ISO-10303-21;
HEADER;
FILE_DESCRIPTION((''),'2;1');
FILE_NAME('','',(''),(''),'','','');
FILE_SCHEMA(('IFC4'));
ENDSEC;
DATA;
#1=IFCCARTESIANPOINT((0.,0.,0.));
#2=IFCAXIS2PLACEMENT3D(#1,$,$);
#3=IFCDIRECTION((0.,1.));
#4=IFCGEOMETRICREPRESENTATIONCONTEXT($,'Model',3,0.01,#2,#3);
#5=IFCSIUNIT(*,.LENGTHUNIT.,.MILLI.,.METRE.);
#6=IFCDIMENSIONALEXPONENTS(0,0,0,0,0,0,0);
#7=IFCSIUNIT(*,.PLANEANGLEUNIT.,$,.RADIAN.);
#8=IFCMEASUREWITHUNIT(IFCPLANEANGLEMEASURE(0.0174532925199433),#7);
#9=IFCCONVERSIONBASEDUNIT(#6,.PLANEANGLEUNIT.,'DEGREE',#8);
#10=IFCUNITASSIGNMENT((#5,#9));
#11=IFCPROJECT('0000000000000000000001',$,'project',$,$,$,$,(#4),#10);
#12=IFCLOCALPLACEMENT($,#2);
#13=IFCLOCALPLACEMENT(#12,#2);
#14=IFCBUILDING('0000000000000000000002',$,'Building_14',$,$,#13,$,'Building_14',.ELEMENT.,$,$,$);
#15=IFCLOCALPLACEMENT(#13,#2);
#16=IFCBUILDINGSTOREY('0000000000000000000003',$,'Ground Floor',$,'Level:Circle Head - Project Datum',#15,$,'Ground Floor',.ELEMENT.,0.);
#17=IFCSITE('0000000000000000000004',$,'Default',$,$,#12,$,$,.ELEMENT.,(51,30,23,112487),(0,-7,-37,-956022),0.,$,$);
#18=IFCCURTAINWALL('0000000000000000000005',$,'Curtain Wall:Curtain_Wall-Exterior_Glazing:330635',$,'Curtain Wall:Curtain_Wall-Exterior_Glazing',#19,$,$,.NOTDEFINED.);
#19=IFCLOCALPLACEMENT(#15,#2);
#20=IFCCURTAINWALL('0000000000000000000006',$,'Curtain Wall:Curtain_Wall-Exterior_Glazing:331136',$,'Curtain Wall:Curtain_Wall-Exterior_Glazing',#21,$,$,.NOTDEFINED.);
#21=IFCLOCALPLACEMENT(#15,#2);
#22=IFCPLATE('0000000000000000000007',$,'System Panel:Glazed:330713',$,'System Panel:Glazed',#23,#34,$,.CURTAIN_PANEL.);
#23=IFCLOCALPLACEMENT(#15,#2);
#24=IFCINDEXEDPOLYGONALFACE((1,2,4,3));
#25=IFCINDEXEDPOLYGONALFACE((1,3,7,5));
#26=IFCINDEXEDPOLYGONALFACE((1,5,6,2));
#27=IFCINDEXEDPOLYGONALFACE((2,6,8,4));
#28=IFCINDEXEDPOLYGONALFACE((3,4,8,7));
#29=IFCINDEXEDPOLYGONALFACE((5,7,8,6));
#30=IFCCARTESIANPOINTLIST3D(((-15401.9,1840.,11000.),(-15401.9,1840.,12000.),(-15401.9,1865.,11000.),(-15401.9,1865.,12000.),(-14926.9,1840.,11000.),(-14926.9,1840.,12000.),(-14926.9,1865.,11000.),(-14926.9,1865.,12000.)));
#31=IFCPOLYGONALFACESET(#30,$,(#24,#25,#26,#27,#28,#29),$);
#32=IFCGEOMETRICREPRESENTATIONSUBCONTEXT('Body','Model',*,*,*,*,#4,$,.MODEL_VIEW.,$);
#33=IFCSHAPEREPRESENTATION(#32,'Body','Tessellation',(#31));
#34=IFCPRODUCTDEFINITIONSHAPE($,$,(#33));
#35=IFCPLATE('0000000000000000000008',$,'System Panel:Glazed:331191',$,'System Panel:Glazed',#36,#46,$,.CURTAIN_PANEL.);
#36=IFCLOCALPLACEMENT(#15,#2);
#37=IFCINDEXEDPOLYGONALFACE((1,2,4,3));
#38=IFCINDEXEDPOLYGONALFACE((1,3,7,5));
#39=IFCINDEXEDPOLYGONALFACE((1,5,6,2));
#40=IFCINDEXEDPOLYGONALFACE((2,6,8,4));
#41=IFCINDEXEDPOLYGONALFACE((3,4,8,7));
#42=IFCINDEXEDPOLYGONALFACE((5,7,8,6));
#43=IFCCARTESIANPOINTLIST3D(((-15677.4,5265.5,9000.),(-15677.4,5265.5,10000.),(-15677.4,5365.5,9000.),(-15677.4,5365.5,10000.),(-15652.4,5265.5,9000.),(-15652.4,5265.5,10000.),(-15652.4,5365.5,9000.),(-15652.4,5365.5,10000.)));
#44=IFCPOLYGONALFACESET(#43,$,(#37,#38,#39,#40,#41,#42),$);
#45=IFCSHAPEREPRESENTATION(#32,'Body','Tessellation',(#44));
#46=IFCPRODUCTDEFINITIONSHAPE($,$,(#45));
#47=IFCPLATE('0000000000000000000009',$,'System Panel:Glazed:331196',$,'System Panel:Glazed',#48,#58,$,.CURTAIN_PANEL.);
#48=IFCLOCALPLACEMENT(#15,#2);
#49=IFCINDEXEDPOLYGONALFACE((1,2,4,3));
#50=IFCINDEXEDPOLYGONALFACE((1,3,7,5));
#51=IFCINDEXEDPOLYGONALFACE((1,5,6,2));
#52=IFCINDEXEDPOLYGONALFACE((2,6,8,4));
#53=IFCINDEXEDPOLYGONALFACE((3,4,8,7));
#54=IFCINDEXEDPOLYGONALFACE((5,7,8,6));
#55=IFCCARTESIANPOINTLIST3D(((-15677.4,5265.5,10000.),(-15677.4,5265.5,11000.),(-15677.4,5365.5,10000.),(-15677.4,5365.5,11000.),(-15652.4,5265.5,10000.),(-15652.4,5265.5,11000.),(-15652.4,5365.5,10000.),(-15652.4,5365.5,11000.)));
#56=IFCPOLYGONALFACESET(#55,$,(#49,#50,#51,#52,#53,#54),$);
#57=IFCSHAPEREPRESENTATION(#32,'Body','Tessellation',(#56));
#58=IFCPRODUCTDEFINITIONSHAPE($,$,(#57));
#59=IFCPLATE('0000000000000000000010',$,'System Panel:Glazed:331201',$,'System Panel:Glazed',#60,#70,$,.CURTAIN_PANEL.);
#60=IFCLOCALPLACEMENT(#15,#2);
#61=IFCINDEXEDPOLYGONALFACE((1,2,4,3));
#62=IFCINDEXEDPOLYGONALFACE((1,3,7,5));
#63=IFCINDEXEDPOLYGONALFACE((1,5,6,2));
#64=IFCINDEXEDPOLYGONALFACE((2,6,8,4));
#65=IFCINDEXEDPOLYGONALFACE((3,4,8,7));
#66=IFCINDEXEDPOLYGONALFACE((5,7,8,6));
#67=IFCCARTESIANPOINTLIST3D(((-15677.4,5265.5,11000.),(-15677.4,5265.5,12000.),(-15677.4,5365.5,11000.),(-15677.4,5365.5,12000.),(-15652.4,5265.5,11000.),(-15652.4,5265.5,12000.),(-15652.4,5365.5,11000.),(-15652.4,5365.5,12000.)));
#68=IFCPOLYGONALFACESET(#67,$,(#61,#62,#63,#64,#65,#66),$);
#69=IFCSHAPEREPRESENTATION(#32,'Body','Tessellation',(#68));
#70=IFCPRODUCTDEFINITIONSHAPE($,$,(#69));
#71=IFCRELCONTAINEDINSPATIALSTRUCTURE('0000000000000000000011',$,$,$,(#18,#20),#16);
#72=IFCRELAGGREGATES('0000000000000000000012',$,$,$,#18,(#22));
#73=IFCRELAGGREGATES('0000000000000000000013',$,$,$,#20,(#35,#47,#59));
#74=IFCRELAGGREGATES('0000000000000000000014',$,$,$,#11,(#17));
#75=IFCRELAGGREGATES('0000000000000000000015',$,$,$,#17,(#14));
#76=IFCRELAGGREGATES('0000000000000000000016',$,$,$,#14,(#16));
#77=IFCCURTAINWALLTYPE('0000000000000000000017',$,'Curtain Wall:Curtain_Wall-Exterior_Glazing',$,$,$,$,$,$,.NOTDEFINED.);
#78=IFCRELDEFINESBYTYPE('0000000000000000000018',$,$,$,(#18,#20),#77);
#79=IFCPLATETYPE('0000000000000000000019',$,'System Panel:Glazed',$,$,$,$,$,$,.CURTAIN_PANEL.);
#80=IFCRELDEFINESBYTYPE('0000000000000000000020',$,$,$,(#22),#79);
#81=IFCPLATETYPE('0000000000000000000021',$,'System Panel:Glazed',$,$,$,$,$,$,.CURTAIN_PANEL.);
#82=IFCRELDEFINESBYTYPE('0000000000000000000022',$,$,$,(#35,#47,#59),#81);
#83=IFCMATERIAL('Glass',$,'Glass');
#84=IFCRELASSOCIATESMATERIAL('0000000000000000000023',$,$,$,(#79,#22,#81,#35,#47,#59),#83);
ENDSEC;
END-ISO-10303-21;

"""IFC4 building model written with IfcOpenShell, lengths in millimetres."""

from ifc_helpers import new_model, entity, si_unit, converted_unit, direction, frame, origin, place, context, subcontext, project, spatial, indexed_curve, outline, extrude, source, transform, mapped, material, type_object, type_shapes, element, aggregate, save


model = new_model("IFC4")

# Units and contexts
model_context = context("Model", 3, precision=0.01, world=origin(), true_north=direction((0.0, 1.0)))
body_context = subcontext(model_context, "Body", "Model", "MODEL_VIEW")
ifc_project = project(units=[si_unit("LENGTHUNIT", "METRE", prefix="MILLI"), converted_unit("PLANEANGLEUNIT", "DEGREE", entity("IfcPlaneAngleMeasure", 0.0174532925199433), si_unit("PLANEANGLEUNIT", "RADIAN"), dimensions=[0, 0, 0, 0, 0, 0, 0])], contexts=[model_context])

# Site, building, storey
site_placement = place(None, origin())
site = spatial("IfcSite", under=ifc_project, at=site_placement, Name="Default", CompositionType="ELEMENT", RefLatitude=(51, 30, 23, 112487), RefLongitude=(0, -7, -37, -956022), RefElevation=0.0)
building_placement = place(site_placement, origin())
building = spatial("IfcBuilding", under=site, at=building_placement, Name="Building_14", LongName="Building_14", CompositionType="ELEMENT")
storey_placement = place(building_placement, origin())
storey = spatial("IfcBuildingStorey", under=building, at=storey_placement, Name="Ground Floor", ObjectType="Level:Circle Head - Project Datum", LongName="Ground Floor", CompositionType="ELEMENT", Elevation=0.0)

# Curtain walls
curtain_wall_type = type_object("IfcCurtainWallType", Name="Curtain Wall:Curtain_Wall-Exterior_Glazing", PredefinedType="NOTDEFINED")
curtain_wall_1_placement = place(storey_placement, origin())
curtain_wall_1 = element("IfcCurtainWall", 1, at=curtain_wall_1_placement, inside=storey, type_object=curtain_wall_type, Name="Curtain Wall:Curtain_Wall-Exterior_Glazing:330635", ObjectType="Curtain Wall:Curtain_Wall-Exterior_Glazing", PredefinedType="NOTDEFINED")
ifc_material = material(Name="Glass", Category="Glass")
curtain_wall_2_placement = place(storey_placement, origin())
curtain_wall_2 = element("IfcCurtainWall", 2, at=curtain_wall_2_placement, inside=storey, type_object=curtain_wall_type, Name="Curtain Wall:Curtain_Wall-Exterior_Glazing:331136", ObjectType="Curtain Wall:Curtain_Wall-Exterior_Glazing", PredefinedType="NOTDEFINED")

# Plates
plate_type_1 = type_object("IfcPlateType", Name="System Panel:Glazed", PredefinedType="CURTAIN_PANEL", material=ifc_material)
shared_shape_1 = source(origin(), body_context, "Body", "SweptSolid", [
    extrude(outline(indexed_curve([(-12.5, -237.5), (12.5, -237.5), (12.5, 237.5), (-12.5, 237.5), (-12.5, -237.5)], self_intersect=False)), frame((0.0, -37.0, 0.0), z_axis=(0.0, 0.0, 1.0), x_axis=(0.0, 1.0, 0.0)), (0.0, 0.0, 1.0), 1000.0),
])
type_shapes(plate_type_1, [shared_shape_1])
plate_1_placement = place(curtain_wall_1_placement, frame((-15164.4, 1815.5, 11000.0), z_axis=(0.0, 0.0, 1.0), x_axis=(-1.0, 0.0, 0.0)))
plate_1 = element("IfcPlate", 3, at=plate_1_placement, type_object=plate_type_1, material=ifc_material, Name="System Panel:Glazed:330713", ObjectType="System Panel:Glazed", PredefinedType="CURTAIN_PANEL", context=body_context, shape_type="MappedRepresentation", body=[
    mapped(shared_shape_1, transform((0.0, 0.0, 0.0), scale=1.0)),
])
aggregate(curtain_wall_1, [plate_1])
plate_type_2 = type_object("IfcPlateType", Name="System Panel:Glazed", PredefinedType="CURTAIN_PANEL", material=ifc_material)
shared_shape_2 = source(origin(), body_context, "Body", "SweptSolid", [
    extrude(outline(indexed_curve([(-12.5, -50.0), (12.5, -50.0), (12.5, 50.0), (-12.5, 50.0), (-12.5, -50.0)], self_intersect=False)), frame((0.0, -37.0, 0.0), z_axis=(0.0, 0.0, 1.0), x_axis=(0.0, 1.0, 0.0)), (0.0, 0.0, 1.0), 1000.0),
])
type_shapes(plate_type_2, [shared_shape_2])
plate_2_placement = place(curtain_wall_2_placement, frame((-15701.9, 5315.5, 9000.0), z_axis=(0.0, 0.0, 1.0), x_axis=(0.0, 1.0, 0.0)))
plate_2 = element("IfcPlate", 4, at=plate_2_placement, type_object=plate_type_2, material=ifc_material, Name="System Panel:Glazed:331191", ObjectType="System Panel:Glazed", PredefinedType="CURTAIN_PANEL", context=body_context, shape_type="MappedRepresentation", body=[
    mapped(shared_shape_2, transform((0.0, 0.0, 0.0), scale=1.0)),
])
plate_3_placement = place(curtain_wall_2_placement, frame((-15701.9, 5315.5, 10000.0), z_axis=(0.0, 0.0, 1.0), x_axis=(0.0, 1.0, 0.0)))
plate_3 = element("IfcPlate", 5, at=plate_3_placement, type_object=plate_type_2, material=ifc_material, Name="System Panel:Glazed:331196", ObjectType="System Panel:Glazed", PredefinedType="CURTAIN_PANEL", context=body_context, shape_type="MappedRepresentation", body=[
    mapped(shared_shape_2, transform((0.0, 0.0, 0.0), scale=1.0)),
])
plate_4_placement = place(curtain_wall_2_placement, frame((-15701.9, 5315.5, 11000.0), z_axis=(0.0, 0.0, 1.0), x_axis=(0.0, 1.0, 0.0)))
plate_4 = element("IfcPlate", 6, at=plate_4_placement, type_object=plate_type_2, material=ifc_material, Name="System Panel:Glazed:331201", ObjectType="System Panel:Glazed", PredefinedType="CURTAIN_PANEL", context=body_context, shape_type="MappedRepresentation", body=[
    mapped(shared_shape_2, transform((0.0, 0.0, 0.0), scale=1.0)),
])
aggregate(curtain_wall_2, [plate_2, plate_3, plate_4])

save(model, "model.ifc")
